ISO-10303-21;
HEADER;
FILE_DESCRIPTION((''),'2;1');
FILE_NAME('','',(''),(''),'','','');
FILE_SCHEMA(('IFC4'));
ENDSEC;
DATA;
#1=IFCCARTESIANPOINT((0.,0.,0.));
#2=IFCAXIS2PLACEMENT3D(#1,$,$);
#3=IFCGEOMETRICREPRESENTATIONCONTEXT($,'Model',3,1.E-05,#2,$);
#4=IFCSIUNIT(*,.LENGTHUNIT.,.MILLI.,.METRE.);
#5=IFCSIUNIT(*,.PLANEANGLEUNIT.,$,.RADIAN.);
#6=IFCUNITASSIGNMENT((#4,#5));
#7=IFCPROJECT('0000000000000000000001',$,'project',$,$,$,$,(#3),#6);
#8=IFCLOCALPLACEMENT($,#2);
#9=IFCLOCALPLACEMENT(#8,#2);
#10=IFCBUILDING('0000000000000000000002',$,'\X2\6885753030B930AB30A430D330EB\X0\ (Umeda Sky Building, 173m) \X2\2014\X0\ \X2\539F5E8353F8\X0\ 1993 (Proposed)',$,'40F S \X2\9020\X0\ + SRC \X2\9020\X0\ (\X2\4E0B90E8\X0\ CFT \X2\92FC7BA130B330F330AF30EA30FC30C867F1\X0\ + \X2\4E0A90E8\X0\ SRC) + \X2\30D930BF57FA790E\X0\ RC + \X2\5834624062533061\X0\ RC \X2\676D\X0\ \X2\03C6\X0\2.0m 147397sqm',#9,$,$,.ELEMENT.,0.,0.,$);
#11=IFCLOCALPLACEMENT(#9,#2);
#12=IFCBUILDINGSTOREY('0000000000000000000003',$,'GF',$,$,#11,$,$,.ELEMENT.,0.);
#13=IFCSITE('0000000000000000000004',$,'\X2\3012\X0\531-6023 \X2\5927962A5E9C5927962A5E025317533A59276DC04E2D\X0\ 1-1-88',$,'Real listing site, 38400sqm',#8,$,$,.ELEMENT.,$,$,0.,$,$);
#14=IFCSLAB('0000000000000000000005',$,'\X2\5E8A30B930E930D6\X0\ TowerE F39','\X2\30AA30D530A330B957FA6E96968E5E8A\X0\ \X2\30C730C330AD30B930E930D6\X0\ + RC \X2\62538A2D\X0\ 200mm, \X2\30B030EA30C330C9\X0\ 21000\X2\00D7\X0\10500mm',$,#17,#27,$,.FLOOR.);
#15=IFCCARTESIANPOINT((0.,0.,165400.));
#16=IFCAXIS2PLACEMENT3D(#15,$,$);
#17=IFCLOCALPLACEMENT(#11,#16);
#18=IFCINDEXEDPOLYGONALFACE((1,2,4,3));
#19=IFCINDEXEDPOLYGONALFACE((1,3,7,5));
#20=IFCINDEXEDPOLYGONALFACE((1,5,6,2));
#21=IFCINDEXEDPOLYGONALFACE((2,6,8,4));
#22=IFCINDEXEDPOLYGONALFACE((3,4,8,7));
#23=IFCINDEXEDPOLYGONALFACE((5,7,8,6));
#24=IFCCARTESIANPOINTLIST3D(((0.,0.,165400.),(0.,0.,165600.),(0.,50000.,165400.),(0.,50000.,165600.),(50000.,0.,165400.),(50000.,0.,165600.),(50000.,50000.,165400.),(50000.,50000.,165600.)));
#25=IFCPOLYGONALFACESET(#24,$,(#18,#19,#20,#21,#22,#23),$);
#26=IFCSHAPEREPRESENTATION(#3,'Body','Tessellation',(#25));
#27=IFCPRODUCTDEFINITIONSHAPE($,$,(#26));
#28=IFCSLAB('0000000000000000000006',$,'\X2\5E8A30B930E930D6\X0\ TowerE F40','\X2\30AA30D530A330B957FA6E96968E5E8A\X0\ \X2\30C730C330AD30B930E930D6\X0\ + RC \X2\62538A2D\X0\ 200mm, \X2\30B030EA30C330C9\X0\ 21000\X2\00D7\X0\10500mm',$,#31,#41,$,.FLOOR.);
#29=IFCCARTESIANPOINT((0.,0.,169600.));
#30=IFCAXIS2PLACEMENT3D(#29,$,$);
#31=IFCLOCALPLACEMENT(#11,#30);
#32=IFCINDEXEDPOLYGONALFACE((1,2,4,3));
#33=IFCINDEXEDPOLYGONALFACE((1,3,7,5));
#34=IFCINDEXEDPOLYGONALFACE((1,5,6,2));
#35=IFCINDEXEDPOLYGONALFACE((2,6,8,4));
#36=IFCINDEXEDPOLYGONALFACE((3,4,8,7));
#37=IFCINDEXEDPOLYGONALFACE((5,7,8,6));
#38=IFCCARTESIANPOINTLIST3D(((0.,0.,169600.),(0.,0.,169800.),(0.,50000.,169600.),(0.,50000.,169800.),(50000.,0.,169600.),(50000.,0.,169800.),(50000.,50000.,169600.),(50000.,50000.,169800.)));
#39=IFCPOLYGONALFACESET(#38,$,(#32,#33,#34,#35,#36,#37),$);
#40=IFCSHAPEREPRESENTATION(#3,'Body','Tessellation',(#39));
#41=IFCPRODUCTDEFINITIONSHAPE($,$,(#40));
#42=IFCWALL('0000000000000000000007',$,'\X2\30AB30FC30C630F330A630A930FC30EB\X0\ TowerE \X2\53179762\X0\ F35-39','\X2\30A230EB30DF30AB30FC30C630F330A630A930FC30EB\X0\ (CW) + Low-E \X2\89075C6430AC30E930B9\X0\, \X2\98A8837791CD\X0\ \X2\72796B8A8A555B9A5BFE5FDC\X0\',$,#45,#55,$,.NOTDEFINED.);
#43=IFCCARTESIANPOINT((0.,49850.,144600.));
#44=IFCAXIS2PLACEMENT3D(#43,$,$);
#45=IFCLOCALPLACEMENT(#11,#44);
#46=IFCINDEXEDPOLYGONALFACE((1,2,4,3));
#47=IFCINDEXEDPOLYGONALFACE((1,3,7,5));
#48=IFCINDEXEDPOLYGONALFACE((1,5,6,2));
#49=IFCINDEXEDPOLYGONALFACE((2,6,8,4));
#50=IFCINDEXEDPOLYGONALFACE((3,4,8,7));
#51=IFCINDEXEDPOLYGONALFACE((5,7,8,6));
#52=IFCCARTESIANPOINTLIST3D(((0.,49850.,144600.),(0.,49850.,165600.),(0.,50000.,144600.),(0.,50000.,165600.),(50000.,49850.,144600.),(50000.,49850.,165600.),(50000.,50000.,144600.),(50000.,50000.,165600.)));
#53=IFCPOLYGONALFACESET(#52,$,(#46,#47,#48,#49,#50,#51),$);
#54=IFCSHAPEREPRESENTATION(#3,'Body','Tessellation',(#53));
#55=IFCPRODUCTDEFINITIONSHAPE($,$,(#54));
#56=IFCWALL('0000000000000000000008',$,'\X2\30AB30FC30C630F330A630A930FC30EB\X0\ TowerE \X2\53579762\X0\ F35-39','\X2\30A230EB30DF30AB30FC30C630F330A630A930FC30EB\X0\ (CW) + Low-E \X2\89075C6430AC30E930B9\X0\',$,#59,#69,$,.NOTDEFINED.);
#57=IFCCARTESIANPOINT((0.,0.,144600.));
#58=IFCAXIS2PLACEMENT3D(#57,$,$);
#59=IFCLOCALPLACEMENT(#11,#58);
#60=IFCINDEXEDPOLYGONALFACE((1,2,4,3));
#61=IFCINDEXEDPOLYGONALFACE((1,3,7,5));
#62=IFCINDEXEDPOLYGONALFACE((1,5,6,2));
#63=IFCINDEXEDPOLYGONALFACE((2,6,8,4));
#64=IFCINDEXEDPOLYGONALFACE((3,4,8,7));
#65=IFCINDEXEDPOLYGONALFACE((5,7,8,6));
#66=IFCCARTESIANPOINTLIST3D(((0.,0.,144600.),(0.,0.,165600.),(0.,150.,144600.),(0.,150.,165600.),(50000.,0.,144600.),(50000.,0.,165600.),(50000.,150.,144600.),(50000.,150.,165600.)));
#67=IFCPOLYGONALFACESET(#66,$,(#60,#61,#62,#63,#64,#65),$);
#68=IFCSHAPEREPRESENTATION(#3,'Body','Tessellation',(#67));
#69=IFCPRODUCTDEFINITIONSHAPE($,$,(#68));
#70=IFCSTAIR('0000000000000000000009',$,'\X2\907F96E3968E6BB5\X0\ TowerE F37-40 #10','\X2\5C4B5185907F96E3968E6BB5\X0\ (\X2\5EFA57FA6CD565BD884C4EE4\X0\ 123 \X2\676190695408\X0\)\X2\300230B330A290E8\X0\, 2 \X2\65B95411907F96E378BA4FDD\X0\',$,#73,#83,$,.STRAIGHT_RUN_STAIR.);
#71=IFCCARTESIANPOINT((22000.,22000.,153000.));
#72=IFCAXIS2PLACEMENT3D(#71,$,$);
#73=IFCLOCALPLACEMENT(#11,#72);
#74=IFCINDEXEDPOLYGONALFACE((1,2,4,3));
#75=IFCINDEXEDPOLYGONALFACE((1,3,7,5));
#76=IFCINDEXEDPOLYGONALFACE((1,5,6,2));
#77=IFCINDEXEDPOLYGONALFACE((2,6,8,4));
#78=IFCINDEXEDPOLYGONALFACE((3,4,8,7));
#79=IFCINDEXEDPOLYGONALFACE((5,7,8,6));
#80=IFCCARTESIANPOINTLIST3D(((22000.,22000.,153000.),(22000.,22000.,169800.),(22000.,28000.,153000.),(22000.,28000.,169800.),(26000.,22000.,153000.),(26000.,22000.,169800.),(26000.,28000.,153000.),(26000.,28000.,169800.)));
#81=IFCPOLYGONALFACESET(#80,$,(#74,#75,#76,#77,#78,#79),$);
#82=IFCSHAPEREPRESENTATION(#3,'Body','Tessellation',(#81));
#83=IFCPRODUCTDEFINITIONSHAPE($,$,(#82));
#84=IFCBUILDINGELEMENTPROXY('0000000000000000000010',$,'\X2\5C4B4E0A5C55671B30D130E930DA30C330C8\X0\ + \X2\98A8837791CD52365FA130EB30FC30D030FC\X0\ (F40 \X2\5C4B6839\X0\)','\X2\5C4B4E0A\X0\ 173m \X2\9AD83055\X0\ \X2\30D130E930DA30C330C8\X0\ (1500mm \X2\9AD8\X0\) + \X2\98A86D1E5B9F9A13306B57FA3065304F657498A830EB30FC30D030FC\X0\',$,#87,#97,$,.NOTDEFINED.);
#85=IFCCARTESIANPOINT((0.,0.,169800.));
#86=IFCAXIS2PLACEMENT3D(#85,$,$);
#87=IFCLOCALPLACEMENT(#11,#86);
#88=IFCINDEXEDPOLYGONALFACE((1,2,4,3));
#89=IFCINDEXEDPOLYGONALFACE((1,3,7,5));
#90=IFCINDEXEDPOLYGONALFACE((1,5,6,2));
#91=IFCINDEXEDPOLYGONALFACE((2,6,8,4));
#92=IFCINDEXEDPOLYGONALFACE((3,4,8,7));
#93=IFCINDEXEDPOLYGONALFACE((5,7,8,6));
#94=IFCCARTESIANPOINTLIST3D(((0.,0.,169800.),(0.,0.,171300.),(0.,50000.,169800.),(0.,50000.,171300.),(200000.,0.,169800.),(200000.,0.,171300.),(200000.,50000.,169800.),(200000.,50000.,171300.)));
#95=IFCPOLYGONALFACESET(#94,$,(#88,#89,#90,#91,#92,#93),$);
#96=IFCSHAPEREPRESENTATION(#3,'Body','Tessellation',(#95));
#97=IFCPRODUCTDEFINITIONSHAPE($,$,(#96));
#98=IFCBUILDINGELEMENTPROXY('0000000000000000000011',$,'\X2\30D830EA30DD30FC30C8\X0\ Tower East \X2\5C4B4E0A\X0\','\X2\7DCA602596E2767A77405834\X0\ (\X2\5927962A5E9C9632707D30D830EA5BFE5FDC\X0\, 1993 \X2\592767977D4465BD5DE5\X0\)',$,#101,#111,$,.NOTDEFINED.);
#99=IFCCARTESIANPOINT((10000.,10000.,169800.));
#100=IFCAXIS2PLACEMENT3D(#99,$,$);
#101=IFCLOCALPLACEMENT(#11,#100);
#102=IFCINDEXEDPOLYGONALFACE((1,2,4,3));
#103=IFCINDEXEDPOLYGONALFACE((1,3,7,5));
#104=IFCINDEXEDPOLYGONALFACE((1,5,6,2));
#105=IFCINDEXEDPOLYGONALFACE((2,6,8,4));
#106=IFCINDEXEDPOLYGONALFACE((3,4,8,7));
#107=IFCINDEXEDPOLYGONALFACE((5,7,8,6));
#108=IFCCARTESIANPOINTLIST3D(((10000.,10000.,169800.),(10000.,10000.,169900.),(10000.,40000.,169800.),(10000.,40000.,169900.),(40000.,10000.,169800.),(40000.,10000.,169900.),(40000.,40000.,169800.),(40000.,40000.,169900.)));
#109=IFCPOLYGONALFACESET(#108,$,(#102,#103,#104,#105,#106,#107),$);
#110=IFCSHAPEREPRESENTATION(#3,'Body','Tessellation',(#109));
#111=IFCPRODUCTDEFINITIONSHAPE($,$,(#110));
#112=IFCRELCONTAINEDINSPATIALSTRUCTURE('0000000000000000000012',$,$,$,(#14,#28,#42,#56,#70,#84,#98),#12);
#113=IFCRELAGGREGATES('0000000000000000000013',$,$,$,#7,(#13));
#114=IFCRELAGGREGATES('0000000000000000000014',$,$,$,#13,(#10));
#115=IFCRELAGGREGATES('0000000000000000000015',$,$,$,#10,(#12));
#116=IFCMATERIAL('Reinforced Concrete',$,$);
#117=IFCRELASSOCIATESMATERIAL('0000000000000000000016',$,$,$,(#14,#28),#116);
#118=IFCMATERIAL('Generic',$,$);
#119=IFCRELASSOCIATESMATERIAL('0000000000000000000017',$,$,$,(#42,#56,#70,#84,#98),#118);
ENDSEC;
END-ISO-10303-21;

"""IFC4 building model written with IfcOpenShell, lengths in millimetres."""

from ifc_helpers import new_model, si_unit, frame, frame_2d, origin, place, context, project, spatial, rectangle, extrude, material, element, save


model = new_model("IFC4")

# Units and contexts
model_context = context("Model", 3, precision=1e-05, world=origin())
ifc_project = project(units=[si_unit("LENGTHUNIT", "METRE", prefix="MILLI"), si_unit("PLANEANGLEUNIT", "RADIAN")], contexts=[model_context])

# Site, building, storey
site_placement = place(None, origin())
site = spatial("IfcSite", under=ifc_project, at=site_placement, Name="〒531-6023 大阪府大阪市北区大淀中 1-1-88", ObjectType="Real listing site, 38400sqm", CompositionType="ELEMENT", RefElevation=0.0)
building_placement = place(site_placement, origin())
building = spatial("IfcBuilding", under=site, at=building_placement, Name="梅田スカイビル (Umeda Sky Building, 173m) — 原広司 1993 (Proposed)", ObjectType="40F S 造 + SRC 造 (下部 CFT 鋼管コンクリート柱 + 上部 SRC) + ベタ基礎 RC + 場所打ち RC 杭 φ2.0m 147397sqm", CompositionType="ELEMENT", ElevationOfRefHeight=0.0, ElevationOfTerrain=0.0)
storey_placement = place(building_placement, origin())
storey = spatial("IfcBuildingStorey", under=building, at=storey_placement, Name="GF", CompositionType="ELEMENT", Elevation=0.0)

# Shared definitions
ifc_material_1 = material(Name="Reinforced Concrete")

# Shared definitions
ifc_material_2 = material(Name="Generic")

# Slabs
slab_1_placement = place(storey_placement, frame((0.0, 0.0, 165400.0)))
element("IfcSlab", 1, at=slab_1_placement, inside=storey, material=ifc_material_1, Name="床スラブ TowerE F39", Description="オフィス基準階床 デッキスラブ + RC 打設 200mm, グリッド 21000×10500mm", PredefinedType="FLOOR", context=model_context, shape_type="SweptSolid", body=[
    extrude(rectangle(XDim=50000.0, YDim=50000.0, at=frame_2d((25000.0, 25000.0))), frame((0.0, 0.0, 165400.0)), (0.0, 0.0, 1.0), 200.0),
])
slab_2_placement = place(storey_placement, frame((0.0, 0.0, 169600.0)))
element("IfcSlab", 2, at=slab_2_placement, inside=storey, material=ifc_material_1, Name="床スラブ TowerE F40", Description="オフィス基準階床 デッキスラブ + RC 打設 200mm, グリッド 21000×10500mm", PredefinedType="FLOOR", context=model_context, shape_type="SweptSolid", body=[
    extrude(rectangle(XDim=50000.0, YDim=50000.0, at=frame_2d((25000.0, 25000.0))), frame((0.0, 0.0, 169600.0)), (0.0, 0.0, 1.0), 200.0),
])

# Walls
wall_1_placement = place(storey_placement, frame((0.0, 49850.0, 144600.0)))
element("IfcWall", 3, at=wall_1_placement, inside=storey, material=ifc_material_2, Name="カーテンウォール TowerE 北面 F35-39", Description="アルミカーテンウォール (CW) + Low-E 複層ガラス, 風荷重 特殊評定対応", PredefinedType="NOTDEFINED", context=model_context, shape_type="SweptSolid", body=[
    extrude(rectangle(XDim=50000.0, YDim=150.0, at=frame_2d((25000.0, 75.0))), frame((0.0, 49850.0, 144600.0)), (0.0, 0.0, 1.0), 21000.0),
])
wall_2_placement = place(storey_placement, frame((0.0, 0.0, 144600.0)))
element("IfcWall", 4, at=wall_2_placement, inside=storey, material=ifc_material_2, Name="カーテンウォール TowerE 南面 F35-39", Description="アルミカーテンウォール (CW) + Low-E 複層ガラス", PredefinedType="NOTDEFINED", context=model_context, shape_type="SweptSolid", body=[
    extrude(rectangle(XDim=50000.0, YDim=150.0, at=frame_2d((25000.0, 75.0))), frame((0.0, 0.0, 144600.0)), (0.0, 0.0, 1.0), 21000.0),
])

# Stair
stair_placement = place(storey_placement, frame((22000.0, 22000.0, 153000.0)))
element("IfcStair", 5, at=stair_placement, inside=storey, material=ifc_material_2, Name="避難階段 TowerE F37-40 #10", Description="屋内避難階段 (建基法施行令 123 条適合)。コア部, 2 方向避難確保", PredefinedType="STRAIGHT_RUN_STAIR", context=model_context, shape_type="SweptSolid", body=[
    extrude(rectangle(XDim=4000.0, YDim=6000.0, at=frame_2d((2000.0, 3000.0))), frame((22000.0, 22000.0, 153000.0)), (0.0, 0.0, 1.0), 16800.0),
])

# Building element proxies
proxy_1_placement = place(storey_placement, frame((0.0, 0.0, 169800.0)))
element("IfcBuildingElementProxy", 6, at=proxy_1_placement, inside=storey, material=ifc_material_2, Name="屋上展望パラペット + 風荷重制御ルーバー (F40 屋根)", Description="屋上 173m 高さ パラペット (1500mm 高) + 風洞実験に基づく整風ルーバー", PredefinedType="NOTDEFINED", context=model_context, shape_type="SweptSolid", body=[
    extrude(rectangle(XDim=200000.0, YDim=50000.0, at=frame_2d((100000.0, 25000.0))), frame((0.0, 0.0, 169800.0)), (0.0, 0.0, 1.0), 1500.0),
])
proxy_2_placement = place(storey_placement, frame((10000.0, 10000.0, 169800.0)))
element("IfcBuildingElementProxy", 7, at=proxy_2_placement, inside=storey, material=ifc_material_2, Name="ヘリポート Tower East 屋上", Description="緊急離発着場 (大阪府防災ヘリ対応, 1993 大林組施工)", PredefinedType="NOTDEFINED", context=model_context, shape_type="SweptSolid", body=[
    extrude(rectangle(XDim=30000.0, YDim=30000.0, at=frame_2d((15000.0, 15000.0))), frame((10000.0, 10000.0, 169800.0)), (0.0, 0.0, 1.0), 100.0),
])

save(model, "model.ifc")
